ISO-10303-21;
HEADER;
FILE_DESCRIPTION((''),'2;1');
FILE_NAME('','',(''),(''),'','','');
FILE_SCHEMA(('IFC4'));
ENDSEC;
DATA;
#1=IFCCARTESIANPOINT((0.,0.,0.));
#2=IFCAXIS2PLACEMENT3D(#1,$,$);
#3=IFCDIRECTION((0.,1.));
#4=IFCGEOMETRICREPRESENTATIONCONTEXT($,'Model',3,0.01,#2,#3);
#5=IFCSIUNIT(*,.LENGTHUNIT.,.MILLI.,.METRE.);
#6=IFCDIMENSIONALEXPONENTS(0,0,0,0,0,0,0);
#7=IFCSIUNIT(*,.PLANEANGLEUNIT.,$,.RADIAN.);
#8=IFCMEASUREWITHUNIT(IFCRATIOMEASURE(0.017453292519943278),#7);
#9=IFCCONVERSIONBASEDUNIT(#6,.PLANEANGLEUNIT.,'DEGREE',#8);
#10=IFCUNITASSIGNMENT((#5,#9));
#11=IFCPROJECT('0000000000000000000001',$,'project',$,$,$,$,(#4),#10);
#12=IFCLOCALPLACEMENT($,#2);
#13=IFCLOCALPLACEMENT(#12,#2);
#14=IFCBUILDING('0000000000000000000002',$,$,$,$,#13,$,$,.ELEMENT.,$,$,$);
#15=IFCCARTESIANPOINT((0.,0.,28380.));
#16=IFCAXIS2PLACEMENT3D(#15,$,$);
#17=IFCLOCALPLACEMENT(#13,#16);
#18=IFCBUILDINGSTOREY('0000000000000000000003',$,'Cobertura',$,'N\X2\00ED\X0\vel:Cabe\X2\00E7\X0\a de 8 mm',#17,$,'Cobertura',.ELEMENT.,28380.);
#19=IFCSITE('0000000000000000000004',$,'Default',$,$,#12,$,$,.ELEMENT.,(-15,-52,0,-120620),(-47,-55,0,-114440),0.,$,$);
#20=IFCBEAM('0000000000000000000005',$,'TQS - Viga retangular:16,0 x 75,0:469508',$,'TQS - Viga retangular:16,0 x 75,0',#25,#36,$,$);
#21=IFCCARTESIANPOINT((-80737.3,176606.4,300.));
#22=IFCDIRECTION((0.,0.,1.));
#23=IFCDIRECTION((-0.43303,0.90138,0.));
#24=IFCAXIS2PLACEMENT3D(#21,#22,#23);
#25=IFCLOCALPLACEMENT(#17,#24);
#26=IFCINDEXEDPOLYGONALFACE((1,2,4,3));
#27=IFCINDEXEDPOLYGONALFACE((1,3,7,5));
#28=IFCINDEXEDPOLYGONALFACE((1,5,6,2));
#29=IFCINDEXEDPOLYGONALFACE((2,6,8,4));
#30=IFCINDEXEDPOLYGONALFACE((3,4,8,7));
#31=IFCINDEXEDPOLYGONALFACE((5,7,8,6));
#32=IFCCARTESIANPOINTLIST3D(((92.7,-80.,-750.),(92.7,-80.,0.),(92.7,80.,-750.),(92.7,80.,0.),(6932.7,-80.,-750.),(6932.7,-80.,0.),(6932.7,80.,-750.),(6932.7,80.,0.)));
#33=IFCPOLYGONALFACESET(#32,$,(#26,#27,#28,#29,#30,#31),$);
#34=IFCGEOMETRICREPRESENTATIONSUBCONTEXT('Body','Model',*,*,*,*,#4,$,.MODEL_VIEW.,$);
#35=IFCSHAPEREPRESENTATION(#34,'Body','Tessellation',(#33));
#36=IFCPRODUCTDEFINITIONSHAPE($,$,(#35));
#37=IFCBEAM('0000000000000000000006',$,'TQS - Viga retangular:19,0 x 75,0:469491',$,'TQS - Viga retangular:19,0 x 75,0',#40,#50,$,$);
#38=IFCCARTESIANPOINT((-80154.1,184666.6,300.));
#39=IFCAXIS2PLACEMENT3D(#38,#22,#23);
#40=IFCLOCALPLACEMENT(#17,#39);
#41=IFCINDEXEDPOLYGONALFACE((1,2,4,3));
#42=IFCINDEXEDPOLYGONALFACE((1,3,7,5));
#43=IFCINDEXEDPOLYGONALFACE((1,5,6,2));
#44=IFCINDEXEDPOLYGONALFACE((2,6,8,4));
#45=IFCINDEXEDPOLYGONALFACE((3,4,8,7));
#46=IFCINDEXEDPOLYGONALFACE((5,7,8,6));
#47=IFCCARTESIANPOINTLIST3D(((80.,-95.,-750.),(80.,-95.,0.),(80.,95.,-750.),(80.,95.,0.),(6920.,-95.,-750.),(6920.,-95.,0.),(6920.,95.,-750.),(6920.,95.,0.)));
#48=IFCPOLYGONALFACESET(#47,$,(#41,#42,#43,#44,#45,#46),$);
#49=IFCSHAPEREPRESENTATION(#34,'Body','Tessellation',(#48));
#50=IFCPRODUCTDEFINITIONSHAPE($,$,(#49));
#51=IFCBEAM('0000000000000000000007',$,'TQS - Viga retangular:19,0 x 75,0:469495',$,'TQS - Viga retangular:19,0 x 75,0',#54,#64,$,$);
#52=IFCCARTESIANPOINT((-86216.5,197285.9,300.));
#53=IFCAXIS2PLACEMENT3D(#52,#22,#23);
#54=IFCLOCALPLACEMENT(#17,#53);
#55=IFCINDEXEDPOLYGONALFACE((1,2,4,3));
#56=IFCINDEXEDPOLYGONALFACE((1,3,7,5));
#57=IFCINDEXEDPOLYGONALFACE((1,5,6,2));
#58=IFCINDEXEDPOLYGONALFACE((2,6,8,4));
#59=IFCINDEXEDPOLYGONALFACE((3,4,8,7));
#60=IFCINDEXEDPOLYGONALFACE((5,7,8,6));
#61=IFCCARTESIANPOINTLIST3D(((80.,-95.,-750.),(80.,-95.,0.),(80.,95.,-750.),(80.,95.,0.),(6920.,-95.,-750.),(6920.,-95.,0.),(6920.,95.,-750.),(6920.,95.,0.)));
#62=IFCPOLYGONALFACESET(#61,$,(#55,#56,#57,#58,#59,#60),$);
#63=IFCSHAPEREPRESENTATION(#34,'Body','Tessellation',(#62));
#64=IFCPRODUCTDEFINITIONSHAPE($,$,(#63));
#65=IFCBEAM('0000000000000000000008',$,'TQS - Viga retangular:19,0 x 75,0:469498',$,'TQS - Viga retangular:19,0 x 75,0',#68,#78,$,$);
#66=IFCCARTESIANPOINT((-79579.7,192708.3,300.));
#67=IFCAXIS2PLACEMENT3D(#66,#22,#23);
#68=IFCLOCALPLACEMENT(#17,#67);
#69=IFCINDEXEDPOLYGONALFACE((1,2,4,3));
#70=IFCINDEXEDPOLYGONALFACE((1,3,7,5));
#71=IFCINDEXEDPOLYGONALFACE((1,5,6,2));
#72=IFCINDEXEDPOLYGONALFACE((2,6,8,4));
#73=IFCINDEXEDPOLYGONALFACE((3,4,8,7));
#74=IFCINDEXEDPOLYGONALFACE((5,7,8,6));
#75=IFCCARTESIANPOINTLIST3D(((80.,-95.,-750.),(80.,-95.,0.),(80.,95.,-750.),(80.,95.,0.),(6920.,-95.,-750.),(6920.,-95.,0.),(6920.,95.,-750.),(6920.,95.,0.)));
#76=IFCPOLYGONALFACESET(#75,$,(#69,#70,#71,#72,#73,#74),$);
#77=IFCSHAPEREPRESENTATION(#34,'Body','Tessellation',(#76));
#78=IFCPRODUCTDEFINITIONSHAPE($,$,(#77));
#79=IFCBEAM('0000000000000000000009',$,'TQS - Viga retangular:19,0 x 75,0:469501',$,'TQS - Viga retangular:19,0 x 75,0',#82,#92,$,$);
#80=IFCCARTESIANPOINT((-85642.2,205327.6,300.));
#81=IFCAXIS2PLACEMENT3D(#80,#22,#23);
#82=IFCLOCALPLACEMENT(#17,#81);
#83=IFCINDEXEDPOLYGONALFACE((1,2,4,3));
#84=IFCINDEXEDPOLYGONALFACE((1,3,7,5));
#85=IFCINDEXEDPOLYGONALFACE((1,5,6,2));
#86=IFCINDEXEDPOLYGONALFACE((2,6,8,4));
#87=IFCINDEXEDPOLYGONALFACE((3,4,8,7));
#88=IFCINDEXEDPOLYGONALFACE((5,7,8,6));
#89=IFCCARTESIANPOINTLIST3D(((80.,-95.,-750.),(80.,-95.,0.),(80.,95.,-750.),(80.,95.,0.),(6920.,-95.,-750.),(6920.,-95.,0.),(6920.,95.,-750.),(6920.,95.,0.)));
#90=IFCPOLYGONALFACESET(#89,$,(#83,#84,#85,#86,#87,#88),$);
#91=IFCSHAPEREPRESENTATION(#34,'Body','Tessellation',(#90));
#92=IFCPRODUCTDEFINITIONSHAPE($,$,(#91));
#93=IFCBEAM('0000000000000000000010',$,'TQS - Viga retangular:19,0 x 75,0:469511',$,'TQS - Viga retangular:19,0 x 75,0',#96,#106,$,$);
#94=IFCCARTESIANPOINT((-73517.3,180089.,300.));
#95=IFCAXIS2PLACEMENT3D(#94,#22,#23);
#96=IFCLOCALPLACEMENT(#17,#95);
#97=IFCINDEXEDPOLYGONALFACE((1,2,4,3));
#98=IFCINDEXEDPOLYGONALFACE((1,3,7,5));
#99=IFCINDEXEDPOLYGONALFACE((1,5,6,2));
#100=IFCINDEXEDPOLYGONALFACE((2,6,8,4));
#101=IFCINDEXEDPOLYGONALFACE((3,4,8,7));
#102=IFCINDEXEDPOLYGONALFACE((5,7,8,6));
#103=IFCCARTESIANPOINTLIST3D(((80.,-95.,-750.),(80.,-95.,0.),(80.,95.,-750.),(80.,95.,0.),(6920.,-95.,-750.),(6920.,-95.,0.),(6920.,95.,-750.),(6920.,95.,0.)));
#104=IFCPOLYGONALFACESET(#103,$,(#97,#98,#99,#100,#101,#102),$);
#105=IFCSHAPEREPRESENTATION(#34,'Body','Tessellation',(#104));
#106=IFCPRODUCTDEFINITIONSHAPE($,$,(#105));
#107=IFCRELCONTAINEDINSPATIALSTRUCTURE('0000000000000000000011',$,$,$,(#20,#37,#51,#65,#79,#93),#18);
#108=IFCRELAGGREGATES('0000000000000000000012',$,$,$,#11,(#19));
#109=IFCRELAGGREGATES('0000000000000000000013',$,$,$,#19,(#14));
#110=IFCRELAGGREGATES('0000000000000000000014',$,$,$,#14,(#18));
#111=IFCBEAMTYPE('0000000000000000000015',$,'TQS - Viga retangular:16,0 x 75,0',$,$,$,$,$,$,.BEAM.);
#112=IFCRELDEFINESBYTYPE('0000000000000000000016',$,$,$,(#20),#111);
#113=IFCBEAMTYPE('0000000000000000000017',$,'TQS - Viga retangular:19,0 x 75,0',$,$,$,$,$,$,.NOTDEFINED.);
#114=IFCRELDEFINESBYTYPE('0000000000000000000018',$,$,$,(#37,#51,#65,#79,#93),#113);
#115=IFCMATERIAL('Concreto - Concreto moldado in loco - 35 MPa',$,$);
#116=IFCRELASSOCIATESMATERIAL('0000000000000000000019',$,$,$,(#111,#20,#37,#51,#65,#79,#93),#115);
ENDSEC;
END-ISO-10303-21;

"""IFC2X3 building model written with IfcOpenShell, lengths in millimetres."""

from ifc_helpers import new_model, entity, si_unit, converted_unit, direction, frame, frame_2d, origin, place, context, subcontext, project, spatial, rectangle, extrude, material, type_object, element, save


model = new_model("IFC2X3")

# Units and contexts
model_context = context("Model", 3, precision=0.01, world=origin(), true_north=direction((0.0, 1.0)))
body_context = subcontext(model_context, "Body", "Model", "MODEL_VIEW")
ifc_project = project(units=[si_unit("LENGTHUNIT", "METRE", prefix="MILLI"), converted_unit("PLANEANGLEUNIT", "DEGREE", entity("IfcRatioMeasure", 0.017453292519943278), si_unit("PLANEANGLEUNIT", "RADIAN"), dimensions=[0, 0, 0, 0, 0, 0, 0])], contexts=[model_context])

# Site, building, storey
site_placement = place(None, origin())
site = spatial("IfcSite", under=ifc_project, at=site_placement, Name="Default", CompositionType="ELEMENT", RefLatitude=(-15, -52, 0, -120620), RefLongitude=(-47, -55, 0, -114440), RefElevation=0.0)
building_placement = place(site_placement, origin())
building = spatial("IfcBuilding", under=site, at=building_placement, CompositionType="ELEMENT")
storey_placement = place(building_placement, frame((0.0, 0.0, 28380.0)))
storey = spatial("IfcBuildingStorey", under=building, at=storey_placement, Name="Cobertura", ObjectType="Nível:Cabeça de 8 mm", LongName="Cobertura", CompositionType="ELEMENT", Elevation=28380.0)

# Beams
ifc_material = material(Name="Concreto - Concreto moldado in loco - 35 MPa")
beam_type_1 = type_object("IfcBeamType", Name="TQS - Viga retangular:16,0 x 75,0", PredefinedType="BEAM", material=ifc_material)
beam_1_placement = place(storey_placement, frame((-80737.3, 176606.4, 300.0), z_axis=(0.0, 0.0, 1.0), x_axis=(-0.43303, 0.90138, 0.0)))
element("IfcBeam", 1, at=beam_1_placement, inside=storey, type_object=beam_type_1, material=ifc_material, Name="TQS - Viga retangular:16,0 x 75,0:469508", ObjectType="TQS - Viga retangular:16,0 x 75,0", context=body_context, shape_type="SweptSolid", body=[
    extrude(rectangle(XDim=750.0, YDim=160.0, at=frame_2d((0.0, 0.0), x_axis=(1.0, 0.0))), frame((92.7, 0.0, -375.0), z_axis=(1.0, 0.0, 0.0), x_axis=(0.0, 0.0, -1.0)), (0.0, 0.0, 1.0), 6840.0),
])
beam_type_2 = type_object("IfcBeamType", Name="TQS - Viga retangular:19,0 x 75,0", PredefinedType="NOTDEFINED")
beam_2_placement = place(storey_placement, frame((-80154.1, 184666.6, 300.0), z_axis=(0.0, 0.0, 1.0), x_axis=(-0.43303, 0.90138, 0.0)))
element("IfcBeam", 2, at=beam_2_placement, inside=storey, type_object=beam_type_2, material=ifc_material, Name="TQS - Viga retangular:19,0 x 75,0:469491", ObjectType="TQS - Viga retangular:19,0 x 75,0", context=body_context, shape_type="SweptSolid", body=[
    extrude(rectangle(XDim=750.0, YDim=190.0, at=frame_2d((0.0, 0.0), x_axis=(1.0, 0.0))), frame((80.0, 0.0, -375.0), z_axis=(1.0, 0.0, 0.0), x_axis=(0.0, 0.0, -1.0)), (0.0, 0.0, 1.0), 6840.0),
])
beam_3_placement = place(storey_placement, frame((-86216.5, 197285.9, 300.0), z_axis=(0.0, 0.0, 1.0), x_axis=(-0.43303, 0.90138, 0.0)))
element("IfcBeam", 3, at=beam_3_placement, inside=storey, type_object=beam_type_2, material=ifc_material, Name="TQS - Viga retangular:19,0 x 75,0:469495", ObjectType="TQS - Viga retangular:19,0 x 75,0", context=body_context, shape_type="SweptSolid", body=[
    extrude(rectangle(XDim=750.0, YDim=190.0, at=frame_2d((0.0, 0.0), x_axis=(1.0, 0.0))), frame((80.0, 0.0, -375.0), z_axis=(1.0, 0.0, 0.0), x_axis=(0.0, 0.0, -1.0)), (0.0, 0.0, 1.0), 6840.0),
])
beam_4_placement = place(storey_placement, frame((-79579.7, 192708.3, 300.0), z_axis=(0.0, 0.0, 1.0), x_axis=(-0.43303, 0.90138, 0.0)))
element("IfcBeam", 4, at=beam_4_placement, inside=storey, type_object=beam_type_2, material=ifc_material, Name="TQS - Viga retangular:19,0 x 75,0:469498", ObjectType="TQS - Viga retangular:19,0 x 75,0", context=body_context, shape_type="SweptSolid", body=[
    extrude(rectangle(XDim=750.0, YDim=190.0, at=frame_2d((0.0, 0.0), x_axis=(1.0, 0.0))), frame((80.0, 0.0, -375.0), z_axis=(1.0, 0.0, 0.0), x_axis=(0.0, 0.0, -1.0)), (0.0, 0.0, 1.0), 6840.0),
])
beam_5_placement = place(storey_placement, frame((-85642.2, 205327.6, 300.0), z_axis=(0.0, 0.0, 1.0), x_axis=(-0.43303, 0.90138, 0.0)))
element("IfcBeam", 5, at=beam_5_placement, inside=storey, type_object=beam_type_2, material=ifc_material, Name="TQS - Viga retangular:19,0 x 75,0:469501", ObjectType="TQS - Viga retangular:19,0 x 75,0", context=body_context, shape_type="SweptSolid", body=[
    extrude(rectangle(XDim=750.0, YDim=190.0, at=frame_2d((0.0, 0.0), x_axis=(1.0, 0.0))), frame((80.0, 0.0, -375.0), z_axis=(1.0, 0.0, 0.0), x_axis=(0.0, 0.0, -1.0)), (0.0, 0.0, 1.0), 6840.0),
])
beam_6_placement = place(storey_placement, frame((-73517.3, 180089.0, 300.0), z_axis=(0.0, 0.0, 1.0), x_axis=(-0.43303, 0.90138, 0.0)))
element("IfcBeam", 6, at=beam_6_placement, inside=storey, type_object=beam_type_2, material=ifc_material, Name="TQS - Viga retangular:19,0 x 75,0:469511", ObjectType="TQS - Viga retangular:19,0 x 75,0", context=body_context, shape_type="SweptSolid", body=[
    extrude(rectangle(XDim=750.0, YDim=190.0, at=frame_2d((0.0, 0.0), x_axis=(1.0, 0.0))), frame((80.0, 0.0, -375.0), z_axis=(1.0, 0.0, 0.0), x_axis=(0.0, 0.0, -1.0)), (0.0, 0.0, 1.0), 6840.0),
])

save(model, "model.ifc")
